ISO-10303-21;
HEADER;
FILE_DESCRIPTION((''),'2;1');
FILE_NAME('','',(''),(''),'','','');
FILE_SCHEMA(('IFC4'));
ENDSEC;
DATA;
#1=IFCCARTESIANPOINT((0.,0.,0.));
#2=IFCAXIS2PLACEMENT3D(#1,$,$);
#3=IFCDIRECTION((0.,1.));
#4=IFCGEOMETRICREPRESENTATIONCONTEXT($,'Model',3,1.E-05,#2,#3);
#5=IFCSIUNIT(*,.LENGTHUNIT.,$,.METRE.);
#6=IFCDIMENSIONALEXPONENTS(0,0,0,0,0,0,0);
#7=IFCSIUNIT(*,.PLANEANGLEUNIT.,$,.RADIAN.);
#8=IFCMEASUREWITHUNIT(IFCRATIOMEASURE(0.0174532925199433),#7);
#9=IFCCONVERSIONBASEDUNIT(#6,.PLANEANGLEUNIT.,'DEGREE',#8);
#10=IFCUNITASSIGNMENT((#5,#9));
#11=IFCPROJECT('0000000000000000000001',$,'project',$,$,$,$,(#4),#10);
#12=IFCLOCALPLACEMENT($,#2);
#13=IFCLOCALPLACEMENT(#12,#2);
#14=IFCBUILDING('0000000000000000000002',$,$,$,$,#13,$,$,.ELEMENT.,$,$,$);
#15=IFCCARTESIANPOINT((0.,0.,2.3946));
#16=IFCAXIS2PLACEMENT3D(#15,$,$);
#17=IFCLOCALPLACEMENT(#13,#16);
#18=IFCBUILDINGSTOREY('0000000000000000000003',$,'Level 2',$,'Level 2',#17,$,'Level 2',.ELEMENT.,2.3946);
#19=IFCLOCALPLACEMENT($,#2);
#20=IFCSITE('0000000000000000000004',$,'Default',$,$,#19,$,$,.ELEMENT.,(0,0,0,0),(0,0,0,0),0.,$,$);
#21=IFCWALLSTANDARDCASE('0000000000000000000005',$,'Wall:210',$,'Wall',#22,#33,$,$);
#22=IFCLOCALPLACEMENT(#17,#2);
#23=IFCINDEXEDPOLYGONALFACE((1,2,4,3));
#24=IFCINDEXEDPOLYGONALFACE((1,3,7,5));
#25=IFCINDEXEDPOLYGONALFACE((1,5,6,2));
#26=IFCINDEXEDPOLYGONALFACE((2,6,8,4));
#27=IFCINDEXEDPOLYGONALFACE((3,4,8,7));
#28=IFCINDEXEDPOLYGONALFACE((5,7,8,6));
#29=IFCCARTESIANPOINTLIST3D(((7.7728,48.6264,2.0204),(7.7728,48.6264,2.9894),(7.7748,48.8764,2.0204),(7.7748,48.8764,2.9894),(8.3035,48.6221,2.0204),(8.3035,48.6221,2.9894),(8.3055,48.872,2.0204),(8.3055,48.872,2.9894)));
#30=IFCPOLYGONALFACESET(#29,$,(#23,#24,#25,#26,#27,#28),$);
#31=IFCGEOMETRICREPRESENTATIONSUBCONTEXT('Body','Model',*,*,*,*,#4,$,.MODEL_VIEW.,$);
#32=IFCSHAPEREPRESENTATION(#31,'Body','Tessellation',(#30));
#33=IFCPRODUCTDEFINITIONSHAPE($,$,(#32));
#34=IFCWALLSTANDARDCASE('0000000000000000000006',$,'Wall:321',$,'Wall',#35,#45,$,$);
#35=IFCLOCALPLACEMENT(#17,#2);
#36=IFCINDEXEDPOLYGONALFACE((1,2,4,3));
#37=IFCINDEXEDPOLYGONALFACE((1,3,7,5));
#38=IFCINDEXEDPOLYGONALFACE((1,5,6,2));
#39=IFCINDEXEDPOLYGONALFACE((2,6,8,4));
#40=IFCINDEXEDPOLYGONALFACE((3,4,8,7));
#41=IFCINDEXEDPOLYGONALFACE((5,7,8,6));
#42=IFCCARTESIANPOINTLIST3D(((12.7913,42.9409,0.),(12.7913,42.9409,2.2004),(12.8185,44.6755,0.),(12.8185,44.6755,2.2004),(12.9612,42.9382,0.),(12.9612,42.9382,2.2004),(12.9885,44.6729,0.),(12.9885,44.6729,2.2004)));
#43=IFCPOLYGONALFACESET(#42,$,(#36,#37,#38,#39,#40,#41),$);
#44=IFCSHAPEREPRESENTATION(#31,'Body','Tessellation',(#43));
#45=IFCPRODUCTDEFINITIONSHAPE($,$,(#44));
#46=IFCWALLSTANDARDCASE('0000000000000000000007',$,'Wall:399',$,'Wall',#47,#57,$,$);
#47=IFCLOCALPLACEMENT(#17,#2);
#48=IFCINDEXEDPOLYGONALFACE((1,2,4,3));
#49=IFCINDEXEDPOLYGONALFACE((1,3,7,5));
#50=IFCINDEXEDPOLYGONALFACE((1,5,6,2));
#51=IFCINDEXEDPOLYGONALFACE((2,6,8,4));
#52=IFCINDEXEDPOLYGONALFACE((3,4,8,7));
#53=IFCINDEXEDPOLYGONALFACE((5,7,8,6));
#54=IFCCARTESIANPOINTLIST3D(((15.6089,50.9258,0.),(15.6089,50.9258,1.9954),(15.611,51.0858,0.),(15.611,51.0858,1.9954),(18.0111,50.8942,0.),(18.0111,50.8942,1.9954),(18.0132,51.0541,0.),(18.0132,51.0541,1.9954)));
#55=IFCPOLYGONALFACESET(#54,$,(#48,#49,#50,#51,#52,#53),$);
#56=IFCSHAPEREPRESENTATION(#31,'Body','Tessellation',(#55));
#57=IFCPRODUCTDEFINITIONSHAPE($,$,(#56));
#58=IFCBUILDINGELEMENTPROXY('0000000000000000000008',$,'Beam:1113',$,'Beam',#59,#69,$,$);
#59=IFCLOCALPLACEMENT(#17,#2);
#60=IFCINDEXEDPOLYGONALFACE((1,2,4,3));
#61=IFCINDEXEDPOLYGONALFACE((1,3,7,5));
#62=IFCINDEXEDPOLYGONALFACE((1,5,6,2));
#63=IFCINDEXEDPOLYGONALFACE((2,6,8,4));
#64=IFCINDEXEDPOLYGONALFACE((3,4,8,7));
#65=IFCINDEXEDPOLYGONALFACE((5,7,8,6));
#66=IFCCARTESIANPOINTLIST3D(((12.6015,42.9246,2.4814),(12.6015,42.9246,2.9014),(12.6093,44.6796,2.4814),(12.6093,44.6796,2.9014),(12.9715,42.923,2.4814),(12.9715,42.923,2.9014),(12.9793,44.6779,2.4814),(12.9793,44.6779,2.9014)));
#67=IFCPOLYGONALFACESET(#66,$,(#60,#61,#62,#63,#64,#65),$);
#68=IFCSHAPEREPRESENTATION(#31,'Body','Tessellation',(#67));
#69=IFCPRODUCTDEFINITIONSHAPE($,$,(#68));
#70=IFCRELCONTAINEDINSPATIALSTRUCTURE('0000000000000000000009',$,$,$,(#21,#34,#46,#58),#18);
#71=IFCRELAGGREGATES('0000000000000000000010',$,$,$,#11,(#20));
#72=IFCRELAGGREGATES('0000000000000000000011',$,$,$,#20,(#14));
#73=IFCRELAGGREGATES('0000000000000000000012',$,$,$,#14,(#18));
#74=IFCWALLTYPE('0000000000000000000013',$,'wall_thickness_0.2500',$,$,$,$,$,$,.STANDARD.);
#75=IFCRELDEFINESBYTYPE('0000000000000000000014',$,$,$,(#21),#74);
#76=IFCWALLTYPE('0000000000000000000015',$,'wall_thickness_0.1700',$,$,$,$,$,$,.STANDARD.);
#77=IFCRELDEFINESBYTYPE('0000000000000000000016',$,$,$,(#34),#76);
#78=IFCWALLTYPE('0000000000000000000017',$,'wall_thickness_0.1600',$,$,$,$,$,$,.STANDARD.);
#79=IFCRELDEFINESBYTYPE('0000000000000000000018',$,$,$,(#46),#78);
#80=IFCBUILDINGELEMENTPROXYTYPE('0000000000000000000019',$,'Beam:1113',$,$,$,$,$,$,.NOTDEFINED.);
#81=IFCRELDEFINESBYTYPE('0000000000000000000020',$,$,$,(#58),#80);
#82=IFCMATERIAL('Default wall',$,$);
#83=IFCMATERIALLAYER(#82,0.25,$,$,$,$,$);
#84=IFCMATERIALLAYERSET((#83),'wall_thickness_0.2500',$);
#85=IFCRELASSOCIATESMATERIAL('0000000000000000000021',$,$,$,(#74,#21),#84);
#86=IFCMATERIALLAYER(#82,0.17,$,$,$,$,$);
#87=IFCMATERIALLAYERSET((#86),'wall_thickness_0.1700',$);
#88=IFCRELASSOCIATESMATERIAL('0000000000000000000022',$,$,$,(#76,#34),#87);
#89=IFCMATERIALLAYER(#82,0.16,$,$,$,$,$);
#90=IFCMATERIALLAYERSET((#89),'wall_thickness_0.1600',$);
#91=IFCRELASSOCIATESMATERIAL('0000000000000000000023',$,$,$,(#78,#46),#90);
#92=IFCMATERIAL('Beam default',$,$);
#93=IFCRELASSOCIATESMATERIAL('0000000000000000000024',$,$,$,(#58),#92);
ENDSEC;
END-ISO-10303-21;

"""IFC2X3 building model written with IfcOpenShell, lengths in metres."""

from ifc_helpers import new_model, entity, si_unit, converted_unit, direction, frame, origin, place, context, subcontext, project, spatial, polyline, outline, extrude, source, transform, mapped, material, layer, layer_set, layer_usage, type_object, type_shapes, element, save


model = new_model("IFC2X3")

# Units and contexts
model_context = context("Model", 3, precision=1e-05, world=origin(), true_north=direction((0.0, 1.0)))
body_context = subcontext(model_context, "Body", "Model", "MODEL_VIEW")
ifc_project = project(units=[si_unit("LENGTHUNIT", "METRE"), converted_unit("PLANEANGLEUNIT", "DEGREE", entity("IfcRatioMeasure", 0.0174532925199433), si_unit("PLANEANGLEUNIT", "RADIAN"), dimensions=[0, 0, 0, 0, 0, 0, 0])], contexts=[model_context])

# Site, building, storey
site_placement = place(None, origin())
site = spatial("IfcSite", under=ifc_project, at=site_placement, Name="Default", CompositionType="ELEMENT", RefLatitude=(0, 0, 0, 0), RefLongitude=(0, 0, 0, 0), RefElevation=0.0)
placement_1 = place(None, origin())
building_placement = place(placement_1, origin())
building = spatial("IfcBuilding", under=site, at=building_placement, CompositionType="ELEMENT")
storey_placement = place(building_placement, frame((0.0, 0.0, 2.3946)))
storey = spatial("IfcBuildingStorey", under=building, at=storey_placement, Name="Level 2", ObjectType="Level 2", LongName="Level 2", CompositionType="ELEMENT", Elevation=2.3946)

# Shared definitions
ifc_material_1 = material(Name="Default wall")

# Walls
ifc_layer_1 = layer(ifc_material_1, 0.25)
ifc_layer_set_1 = layer_set([ifc_layer_1], Name="wall_thickness_0.2500")
ifc_layer_usage_1 = layer_usage(ifc_layer_set_1, "AXIS2", "POSITIVE", -0.125)
wall_type_1 = type_object("IfcWallType", Name="wall_thickness_0.2500", PredefinedType="STANDARD", material=ifc_layer_set_1)
placement_2 = place(building_placement, frame((0.0, 0.0, 4.415)))
wall_1_placement = place(placement_2, frame((7.7738, 48.7514, 0.0), z_axis=(0.0, 0.0, 1.0), x_axis=(0.999967, -0.008122, 0.0)))
element("IfcWallStandardCase", 1, at=wall_1_placement, inside=storey, type_object=wall_type_1, material=ifc_layer_usage_1, Name="Wall:210", ObjectType="Wall", context=body_context, shape_type="SweptSolid", body=[
    extrude(outline(polyline([(0.5307, -0.125), (0.5307, 0.125), (0.0, 0.125), (0.0, -0.125), (0.5307, -0.125)])), origin(), (0.0, 0.0, 1.0), 0.969),
])
ifc_layer_2 = layer(ifc_material_1, 0.17)
ifc_layer_set_2 = layer_set([ifc_layer_2], Name="wall_thickness_0.1700")
ifc_layer_usage_2 = layer_usage(ifc_layer_set_2, "AXIS2", "POSITIVE", -0.085)
wall_type_2 = type_object("IfcWallType", Name="wall_thickness_0.1700", PredefinedType="STANDARD", material=ifc_layer_set_2)
wall_2_placement = place(storey_placement, frame((12.9035, 44.6742, 0.0), z_axis=(0.0, 0.0, 1.0), x_axis=(-0.015715, -0.999877, 0.0)))
element("IfcWallStandardCase", 2, at=wall_2_placement, inside=storey, type_object=wall_type_2, material=ifc_layer_usage_2, Name="Wall:321", ObjectType="Wall", context=body_context, shape_type="SweptSolid", body=[
    extrude(outline(polyline([(1.7349, -0.085), (1.7349, 0.085), (0.0, 0.085), (0.0, -0.085), (1.7349, -0.085)])), origin(), (0.0, 0.0, 1.0), 2.2004),
])
ifc_layer_3 = layer(ifc_material_1, 0.16)
ifc_layer_set_3 = layer_set([ifc_layer_3], Name="wall_thickness_0.1600")
ifc_layer_usage_3 = layer_usage(ifc_layer_set_3, "AXIS2", "POSITIVE", -0.08)
wall_type_3 = type_object("IfcWallType", Name="wall_thickness_0.1600", PredefinedType="STANDARD", material=ifc_layer_set_3)
wall_3_placement = place(storey_placement, frame((15.61, 51.0058, 0.0), z_axis=(0.0, 0.0, 1.0), x_axis=(0.999913, -0.013191, 0.0)))
element("IfcWallStandardCase", 3, at=wall_3_placement, inside=storey, type_object=wall_type_3, material=ifc_layer_usage_3, Name="Wall:399", ObjectType="Wall", context=body_context, shape_type="SweptSolid", body=[
    extrude(outline(polyline([(2.4023, -0.08), (2.4023, 0.08), (0.0, 0.08), (0.0, -0.08), (2.4023, -0.08)])), origin(), (0.0, 0.0, 1.0), 1.9954),
])

# Building element proxy
ifc_material_2 = material(Name="Beam default")
building_element_proxy_type = type_object("IfcBuildingElementProxyType", Name="Beam:1113", PredefinedType="NOTDEFINED")
shared_shape_1 = source(origin(), body_context, "Body", "SweptSolid", [
    extrude(outline(polyline([(1.755, -0.185), (1.755, 0.185), (0.0, 0.185), (0.0, -0.185), (1.755, -0.185)])), origin(), (0.0, 0.0, 1.0), 0.42),
])
type_shapes(building_element_proxy_type, [shared_shape_1])
placement_3 = place(building_placement, frame((0.0, 0.0, 4.876)))
proxy_placement = place(placement_3, frame((12.7943, 44.6787, 0.0), z_axis=(0.0, 0.0, 1.0), x_axis=(-0.004436, -0.99999, 0.0)))
element("IfcBuildingElementProxy", 4, at=proxy_placement, inside=storey, type_object=building_element_proxy_type, material=ifc_material_2, Name="Beam:1113", ObjectType="Beam", context=body_context, shape_type="MappedRepresentation", body=[
    mapped(shared_shape_1, transform((0.0, 0.0, 0.0), scale=1.0)),
])

save(model, "model.ifc")
